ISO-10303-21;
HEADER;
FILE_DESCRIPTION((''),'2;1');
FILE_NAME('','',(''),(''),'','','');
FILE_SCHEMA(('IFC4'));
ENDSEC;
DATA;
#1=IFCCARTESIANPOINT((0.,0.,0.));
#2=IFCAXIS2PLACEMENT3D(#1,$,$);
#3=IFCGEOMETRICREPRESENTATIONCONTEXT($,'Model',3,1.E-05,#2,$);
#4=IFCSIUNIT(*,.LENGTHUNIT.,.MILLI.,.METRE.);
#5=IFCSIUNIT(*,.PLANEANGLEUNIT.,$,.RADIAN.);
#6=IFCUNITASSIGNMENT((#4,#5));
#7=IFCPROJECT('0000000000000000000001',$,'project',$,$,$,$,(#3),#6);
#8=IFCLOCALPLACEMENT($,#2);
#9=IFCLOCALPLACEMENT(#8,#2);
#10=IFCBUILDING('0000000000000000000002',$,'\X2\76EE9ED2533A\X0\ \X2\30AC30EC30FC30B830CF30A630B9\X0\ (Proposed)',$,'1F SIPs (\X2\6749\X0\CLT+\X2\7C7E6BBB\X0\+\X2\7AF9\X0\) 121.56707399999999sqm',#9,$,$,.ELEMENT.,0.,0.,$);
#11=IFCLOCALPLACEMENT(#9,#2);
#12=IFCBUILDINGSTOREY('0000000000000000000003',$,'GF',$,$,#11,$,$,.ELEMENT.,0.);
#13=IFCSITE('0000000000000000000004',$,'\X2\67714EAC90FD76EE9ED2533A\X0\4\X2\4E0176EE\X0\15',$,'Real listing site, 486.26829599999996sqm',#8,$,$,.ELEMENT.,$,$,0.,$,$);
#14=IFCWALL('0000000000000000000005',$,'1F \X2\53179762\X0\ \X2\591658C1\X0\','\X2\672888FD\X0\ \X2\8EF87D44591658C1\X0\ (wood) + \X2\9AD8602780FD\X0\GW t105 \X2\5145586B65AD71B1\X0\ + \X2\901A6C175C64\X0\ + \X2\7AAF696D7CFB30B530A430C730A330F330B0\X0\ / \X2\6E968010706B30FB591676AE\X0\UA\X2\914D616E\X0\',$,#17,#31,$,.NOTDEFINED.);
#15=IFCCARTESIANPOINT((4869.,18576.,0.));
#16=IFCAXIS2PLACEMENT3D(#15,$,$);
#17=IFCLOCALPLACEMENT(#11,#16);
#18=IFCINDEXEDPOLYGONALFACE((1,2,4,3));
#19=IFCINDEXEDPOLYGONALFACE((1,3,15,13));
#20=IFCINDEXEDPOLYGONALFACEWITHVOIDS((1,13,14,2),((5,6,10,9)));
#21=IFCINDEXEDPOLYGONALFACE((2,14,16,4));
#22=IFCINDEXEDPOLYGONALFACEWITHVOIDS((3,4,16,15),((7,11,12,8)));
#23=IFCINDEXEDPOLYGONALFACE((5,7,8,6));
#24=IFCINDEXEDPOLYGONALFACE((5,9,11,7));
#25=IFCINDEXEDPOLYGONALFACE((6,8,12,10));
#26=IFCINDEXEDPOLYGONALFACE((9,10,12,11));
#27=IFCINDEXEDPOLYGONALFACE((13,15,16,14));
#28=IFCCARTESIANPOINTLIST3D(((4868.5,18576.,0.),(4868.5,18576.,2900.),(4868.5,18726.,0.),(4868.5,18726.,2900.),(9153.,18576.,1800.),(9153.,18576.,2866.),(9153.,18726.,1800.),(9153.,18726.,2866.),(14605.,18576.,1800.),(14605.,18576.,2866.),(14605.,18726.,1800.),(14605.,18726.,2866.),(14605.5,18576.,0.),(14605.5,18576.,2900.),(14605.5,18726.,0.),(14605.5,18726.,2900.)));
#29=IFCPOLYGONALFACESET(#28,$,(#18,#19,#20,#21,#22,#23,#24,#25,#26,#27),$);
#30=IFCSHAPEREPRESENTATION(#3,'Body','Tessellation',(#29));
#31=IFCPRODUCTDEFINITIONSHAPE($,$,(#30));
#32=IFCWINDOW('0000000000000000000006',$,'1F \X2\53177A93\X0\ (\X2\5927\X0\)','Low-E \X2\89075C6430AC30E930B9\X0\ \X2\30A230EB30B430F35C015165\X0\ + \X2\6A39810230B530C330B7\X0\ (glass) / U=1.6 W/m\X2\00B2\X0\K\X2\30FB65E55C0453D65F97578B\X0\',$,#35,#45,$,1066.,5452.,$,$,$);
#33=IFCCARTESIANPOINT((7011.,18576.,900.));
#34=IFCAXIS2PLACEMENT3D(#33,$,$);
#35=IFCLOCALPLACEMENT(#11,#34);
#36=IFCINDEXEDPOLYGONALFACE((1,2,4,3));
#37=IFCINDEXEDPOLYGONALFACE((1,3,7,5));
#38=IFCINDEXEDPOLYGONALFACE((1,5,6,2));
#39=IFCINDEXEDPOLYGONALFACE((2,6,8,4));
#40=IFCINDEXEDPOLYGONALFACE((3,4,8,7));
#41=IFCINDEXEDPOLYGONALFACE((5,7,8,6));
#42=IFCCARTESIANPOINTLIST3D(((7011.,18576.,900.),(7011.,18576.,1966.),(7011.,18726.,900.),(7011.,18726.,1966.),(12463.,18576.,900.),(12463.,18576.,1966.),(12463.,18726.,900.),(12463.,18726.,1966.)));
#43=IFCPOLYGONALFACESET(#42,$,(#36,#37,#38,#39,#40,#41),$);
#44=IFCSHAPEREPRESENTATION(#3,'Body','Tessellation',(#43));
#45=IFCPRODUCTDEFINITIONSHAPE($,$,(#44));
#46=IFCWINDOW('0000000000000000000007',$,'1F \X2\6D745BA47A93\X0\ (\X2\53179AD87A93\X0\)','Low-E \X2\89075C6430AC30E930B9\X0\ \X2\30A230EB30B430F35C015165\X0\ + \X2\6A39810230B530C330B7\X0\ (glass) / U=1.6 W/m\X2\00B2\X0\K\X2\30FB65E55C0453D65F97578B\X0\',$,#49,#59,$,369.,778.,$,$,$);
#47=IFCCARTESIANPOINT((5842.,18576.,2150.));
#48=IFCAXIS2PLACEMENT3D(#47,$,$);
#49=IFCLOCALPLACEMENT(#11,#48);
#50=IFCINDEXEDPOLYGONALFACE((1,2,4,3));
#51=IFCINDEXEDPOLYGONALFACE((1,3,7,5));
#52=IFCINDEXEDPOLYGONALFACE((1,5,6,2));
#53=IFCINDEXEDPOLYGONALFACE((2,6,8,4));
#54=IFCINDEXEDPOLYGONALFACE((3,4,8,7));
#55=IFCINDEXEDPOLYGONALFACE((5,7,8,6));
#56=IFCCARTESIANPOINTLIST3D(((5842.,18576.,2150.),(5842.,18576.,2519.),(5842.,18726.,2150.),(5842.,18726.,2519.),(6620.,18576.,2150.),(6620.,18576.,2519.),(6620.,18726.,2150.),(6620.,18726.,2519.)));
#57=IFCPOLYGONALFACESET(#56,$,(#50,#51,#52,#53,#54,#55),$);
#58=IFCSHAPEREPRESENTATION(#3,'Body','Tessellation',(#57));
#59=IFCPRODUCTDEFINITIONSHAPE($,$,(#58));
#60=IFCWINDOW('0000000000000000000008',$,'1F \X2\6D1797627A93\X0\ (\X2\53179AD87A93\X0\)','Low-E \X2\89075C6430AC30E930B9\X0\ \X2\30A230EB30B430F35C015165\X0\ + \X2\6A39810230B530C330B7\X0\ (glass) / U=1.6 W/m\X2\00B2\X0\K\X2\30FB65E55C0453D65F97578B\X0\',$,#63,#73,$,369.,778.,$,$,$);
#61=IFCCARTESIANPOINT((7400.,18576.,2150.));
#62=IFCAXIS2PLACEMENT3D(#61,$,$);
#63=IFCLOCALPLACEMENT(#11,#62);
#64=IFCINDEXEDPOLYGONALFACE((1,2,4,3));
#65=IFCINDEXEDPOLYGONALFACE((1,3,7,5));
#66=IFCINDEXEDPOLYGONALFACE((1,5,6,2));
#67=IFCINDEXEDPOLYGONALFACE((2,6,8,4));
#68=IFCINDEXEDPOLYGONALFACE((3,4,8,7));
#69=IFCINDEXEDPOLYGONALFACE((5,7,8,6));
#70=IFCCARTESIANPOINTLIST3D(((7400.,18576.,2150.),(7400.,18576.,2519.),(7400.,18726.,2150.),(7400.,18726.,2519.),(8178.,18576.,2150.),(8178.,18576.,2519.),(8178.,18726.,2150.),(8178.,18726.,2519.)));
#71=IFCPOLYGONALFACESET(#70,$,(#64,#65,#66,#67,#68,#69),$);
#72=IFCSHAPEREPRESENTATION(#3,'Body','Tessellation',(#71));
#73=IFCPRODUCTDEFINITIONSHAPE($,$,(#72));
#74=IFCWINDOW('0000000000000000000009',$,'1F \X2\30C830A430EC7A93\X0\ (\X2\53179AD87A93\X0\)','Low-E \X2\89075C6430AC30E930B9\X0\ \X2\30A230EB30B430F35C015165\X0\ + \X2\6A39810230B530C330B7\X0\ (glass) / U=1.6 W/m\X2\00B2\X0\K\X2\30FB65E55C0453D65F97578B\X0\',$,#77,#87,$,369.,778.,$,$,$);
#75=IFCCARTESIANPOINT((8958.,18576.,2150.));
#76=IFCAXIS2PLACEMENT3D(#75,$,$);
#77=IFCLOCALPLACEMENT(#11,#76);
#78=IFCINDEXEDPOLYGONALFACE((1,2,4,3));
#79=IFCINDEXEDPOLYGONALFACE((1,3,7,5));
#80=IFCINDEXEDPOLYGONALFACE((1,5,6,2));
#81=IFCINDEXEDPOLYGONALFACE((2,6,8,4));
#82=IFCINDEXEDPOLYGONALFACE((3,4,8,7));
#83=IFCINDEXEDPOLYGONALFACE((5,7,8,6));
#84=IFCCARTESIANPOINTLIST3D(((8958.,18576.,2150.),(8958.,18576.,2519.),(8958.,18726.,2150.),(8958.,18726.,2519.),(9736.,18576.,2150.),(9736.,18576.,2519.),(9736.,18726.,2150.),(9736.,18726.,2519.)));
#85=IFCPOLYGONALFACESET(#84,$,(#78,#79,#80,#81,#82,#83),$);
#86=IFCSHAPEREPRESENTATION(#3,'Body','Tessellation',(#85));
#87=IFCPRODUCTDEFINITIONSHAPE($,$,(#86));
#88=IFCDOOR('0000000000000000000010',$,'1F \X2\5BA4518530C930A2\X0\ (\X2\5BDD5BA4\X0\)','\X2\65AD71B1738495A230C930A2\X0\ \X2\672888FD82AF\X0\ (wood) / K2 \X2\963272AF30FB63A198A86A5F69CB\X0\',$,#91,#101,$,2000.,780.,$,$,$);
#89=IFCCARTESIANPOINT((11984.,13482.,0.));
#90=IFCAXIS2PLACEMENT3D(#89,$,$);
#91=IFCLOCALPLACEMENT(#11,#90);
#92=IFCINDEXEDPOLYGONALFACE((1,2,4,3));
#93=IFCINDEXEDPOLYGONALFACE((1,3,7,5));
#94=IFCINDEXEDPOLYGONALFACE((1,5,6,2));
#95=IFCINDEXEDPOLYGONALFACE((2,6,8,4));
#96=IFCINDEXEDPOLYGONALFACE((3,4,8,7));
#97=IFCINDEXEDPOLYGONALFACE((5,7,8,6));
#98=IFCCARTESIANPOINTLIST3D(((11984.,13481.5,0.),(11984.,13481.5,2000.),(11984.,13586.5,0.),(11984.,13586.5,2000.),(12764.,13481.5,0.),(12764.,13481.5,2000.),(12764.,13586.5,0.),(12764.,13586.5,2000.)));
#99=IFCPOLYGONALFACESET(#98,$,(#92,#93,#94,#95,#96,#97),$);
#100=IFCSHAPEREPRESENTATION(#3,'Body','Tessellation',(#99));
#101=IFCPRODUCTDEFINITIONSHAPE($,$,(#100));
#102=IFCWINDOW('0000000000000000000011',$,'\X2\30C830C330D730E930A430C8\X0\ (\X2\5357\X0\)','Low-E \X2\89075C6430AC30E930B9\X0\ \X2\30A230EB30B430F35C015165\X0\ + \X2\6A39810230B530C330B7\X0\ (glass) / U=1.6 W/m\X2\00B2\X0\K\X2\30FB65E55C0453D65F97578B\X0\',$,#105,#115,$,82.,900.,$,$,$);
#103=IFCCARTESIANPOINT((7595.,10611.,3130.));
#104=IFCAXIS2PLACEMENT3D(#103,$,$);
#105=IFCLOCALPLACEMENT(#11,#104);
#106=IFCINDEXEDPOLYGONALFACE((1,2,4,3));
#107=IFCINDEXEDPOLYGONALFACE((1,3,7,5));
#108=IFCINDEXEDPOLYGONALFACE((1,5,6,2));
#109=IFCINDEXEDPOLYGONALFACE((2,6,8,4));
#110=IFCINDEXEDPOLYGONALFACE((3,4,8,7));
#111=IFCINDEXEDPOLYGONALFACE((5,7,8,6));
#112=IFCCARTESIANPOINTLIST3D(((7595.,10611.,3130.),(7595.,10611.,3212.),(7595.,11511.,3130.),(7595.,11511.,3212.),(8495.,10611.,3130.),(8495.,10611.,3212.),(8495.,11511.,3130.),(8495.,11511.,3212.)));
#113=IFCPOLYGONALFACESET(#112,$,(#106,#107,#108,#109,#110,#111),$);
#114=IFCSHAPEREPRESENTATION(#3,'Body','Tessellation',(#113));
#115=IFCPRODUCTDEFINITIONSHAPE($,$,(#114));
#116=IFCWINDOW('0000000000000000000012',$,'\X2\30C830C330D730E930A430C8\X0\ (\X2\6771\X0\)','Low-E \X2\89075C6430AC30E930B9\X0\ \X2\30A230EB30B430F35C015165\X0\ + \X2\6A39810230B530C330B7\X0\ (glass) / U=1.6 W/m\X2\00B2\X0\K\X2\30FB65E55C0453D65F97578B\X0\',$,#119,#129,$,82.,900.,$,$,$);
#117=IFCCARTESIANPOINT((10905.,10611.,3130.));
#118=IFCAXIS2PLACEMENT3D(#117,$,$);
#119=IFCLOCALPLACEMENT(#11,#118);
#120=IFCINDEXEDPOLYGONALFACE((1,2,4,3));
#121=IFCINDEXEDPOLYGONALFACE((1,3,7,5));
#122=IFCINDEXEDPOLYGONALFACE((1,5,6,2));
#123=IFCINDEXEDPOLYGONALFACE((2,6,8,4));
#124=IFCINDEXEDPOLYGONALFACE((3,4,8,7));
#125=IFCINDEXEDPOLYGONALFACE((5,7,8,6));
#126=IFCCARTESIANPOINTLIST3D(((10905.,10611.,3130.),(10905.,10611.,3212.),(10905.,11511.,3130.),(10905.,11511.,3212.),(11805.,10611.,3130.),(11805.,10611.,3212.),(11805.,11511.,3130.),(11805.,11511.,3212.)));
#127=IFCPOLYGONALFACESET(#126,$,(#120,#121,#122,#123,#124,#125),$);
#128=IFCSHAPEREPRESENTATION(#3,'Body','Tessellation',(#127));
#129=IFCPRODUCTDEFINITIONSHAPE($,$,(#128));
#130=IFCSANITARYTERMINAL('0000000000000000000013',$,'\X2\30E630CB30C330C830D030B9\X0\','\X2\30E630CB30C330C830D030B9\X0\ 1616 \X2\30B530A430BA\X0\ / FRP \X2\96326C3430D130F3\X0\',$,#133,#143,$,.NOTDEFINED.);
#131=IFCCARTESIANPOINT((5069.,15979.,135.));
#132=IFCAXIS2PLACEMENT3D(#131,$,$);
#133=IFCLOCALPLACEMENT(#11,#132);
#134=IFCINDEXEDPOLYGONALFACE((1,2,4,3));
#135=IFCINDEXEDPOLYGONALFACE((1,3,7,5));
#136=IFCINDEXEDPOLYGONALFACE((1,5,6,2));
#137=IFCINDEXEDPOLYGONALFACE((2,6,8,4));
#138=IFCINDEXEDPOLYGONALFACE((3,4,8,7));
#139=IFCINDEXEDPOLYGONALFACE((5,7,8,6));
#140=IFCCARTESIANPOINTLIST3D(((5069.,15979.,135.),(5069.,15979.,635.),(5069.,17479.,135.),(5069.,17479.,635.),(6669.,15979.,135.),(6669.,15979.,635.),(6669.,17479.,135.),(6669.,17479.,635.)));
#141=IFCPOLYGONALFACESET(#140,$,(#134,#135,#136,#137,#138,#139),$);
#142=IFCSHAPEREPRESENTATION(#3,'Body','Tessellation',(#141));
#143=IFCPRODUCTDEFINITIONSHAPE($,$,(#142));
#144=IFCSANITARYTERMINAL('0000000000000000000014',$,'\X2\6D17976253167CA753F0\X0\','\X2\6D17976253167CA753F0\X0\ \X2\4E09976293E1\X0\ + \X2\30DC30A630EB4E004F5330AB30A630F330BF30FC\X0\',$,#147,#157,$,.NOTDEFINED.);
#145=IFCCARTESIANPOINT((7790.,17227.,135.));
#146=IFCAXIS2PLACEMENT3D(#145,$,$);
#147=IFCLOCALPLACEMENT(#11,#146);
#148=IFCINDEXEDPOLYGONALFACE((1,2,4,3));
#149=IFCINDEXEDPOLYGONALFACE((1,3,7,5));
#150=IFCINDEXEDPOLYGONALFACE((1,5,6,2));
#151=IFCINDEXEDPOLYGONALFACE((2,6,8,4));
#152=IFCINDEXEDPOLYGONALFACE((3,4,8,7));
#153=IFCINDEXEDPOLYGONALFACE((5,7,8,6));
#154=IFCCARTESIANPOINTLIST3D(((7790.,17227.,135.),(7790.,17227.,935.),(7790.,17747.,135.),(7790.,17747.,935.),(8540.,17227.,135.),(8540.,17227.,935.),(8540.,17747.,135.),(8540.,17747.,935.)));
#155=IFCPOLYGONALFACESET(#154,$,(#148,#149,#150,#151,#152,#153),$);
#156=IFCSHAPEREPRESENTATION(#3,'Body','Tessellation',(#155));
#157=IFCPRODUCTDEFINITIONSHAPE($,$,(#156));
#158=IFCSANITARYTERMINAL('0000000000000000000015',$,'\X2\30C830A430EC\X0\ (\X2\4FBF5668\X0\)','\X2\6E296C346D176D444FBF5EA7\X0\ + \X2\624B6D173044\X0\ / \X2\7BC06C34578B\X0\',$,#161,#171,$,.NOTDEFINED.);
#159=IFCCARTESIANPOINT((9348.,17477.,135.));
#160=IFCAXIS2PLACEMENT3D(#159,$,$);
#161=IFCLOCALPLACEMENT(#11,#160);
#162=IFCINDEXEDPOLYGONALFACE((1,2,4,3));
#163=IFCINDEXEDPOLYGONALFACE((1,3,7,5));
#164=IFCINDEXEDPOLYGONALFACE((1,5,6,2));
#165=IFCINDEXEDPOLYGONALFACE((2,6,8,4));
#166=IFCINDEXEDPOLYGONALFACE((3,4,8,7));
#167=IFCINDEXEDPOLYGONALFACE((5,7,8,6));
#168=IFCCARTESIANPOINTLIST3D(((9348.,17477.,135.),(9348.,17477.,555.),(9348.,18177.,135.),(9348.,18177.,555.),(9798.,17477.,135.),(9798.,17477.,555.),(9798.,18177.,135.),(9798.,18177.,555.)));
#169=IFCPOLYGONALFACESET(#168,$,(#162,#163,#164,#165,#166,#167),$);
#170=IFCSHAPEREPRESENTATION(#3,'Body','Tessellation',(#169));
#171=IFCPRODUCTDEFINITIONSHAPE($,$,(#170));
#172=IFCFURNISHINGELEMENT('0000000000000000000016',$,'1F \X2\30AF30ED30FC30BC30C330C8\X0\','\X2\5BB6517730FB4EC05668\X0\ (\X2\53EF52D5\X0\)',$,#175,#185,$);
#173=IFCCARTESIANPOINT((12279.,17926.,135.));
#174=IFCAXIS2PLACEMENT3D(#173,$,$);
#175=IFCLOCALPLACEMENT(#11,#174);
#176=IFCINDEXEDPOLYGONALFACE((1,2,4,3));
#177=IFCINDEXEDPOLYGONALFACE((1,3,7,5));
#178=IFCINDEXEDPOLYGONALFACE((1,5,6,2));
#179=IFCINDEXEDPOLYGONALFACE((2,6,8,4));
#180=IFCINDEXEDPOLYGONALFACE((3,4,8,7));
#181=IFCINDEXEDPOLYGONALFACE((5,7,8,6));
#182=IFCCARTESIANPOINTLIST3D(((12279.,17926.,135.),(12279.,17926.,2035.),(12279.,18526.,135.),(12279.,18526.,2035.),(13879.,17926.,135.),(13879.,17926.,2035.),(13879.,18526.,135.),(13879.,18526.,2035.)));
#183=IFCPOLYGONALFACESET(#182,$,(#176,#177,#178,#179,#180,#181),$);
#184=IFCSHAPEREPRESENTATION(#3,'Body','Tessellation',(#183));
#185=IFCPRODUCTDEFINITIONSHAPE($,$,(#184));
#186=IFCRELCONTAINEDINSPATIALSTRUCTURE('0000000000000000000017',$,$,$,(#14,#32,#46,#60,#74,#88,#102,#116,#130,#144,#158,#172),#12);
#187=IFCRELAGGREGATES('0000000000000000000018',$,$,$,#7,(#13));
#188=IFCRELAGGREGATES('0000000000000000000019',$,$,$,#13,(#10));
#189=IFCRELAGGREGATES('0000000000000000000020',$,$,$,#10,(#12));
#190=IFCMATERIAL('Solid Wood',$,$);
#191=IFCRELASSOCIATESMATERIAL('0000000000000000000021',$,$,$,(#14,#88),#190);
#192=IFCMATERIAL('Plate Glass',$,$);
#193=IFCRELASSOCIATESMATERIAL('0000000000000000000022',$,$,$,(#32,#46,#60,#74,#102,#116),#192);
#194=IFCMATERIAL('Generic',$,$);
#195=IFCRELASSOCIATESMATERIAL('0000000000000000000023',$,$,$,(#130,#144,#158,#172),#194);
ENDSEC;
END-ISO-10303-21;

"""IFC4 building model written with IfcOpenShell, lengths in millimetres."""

from ifc_helpers import new_model, si_unit, frame, frame_2d, origin, place, context, project, spatial, rectangle, extrude, material, element, fill, save


model = new_model("IFC4")

# Units and contexts
model_context = context("Model", 3, precision=1e-05, world=origin())
ifc_project = project(units=[si_unit("LENGTHUNIT", "METRE", prefix="MILLI"), si_unit("PLANEANGLEUNIT", "RADIAN")], contexts=[model_context])

# Site, building, storey
site_placement = place(None, origin())
site = spatial("IfcSite", under=ifc_project, at=site_placement, Name="東京都目黒区4丁目15", ObjectType="Real listing site, 486.26829599999996sqm", CompositionType="ELEMENT", RefElevation=0.0)
building_placement = place(site_placement, origin())
building = spatial("IfcBuilding", under=site, at=building_placement, Name="目黒区 ガレージハウス (Proposed)", ObjectType="1F SIPs (杉CLT+籾殻+竹) 121.56707399999999sqm", CompositionType="ELEMENT", ElevationOfRefHeight=0.0, ElevationOfTerrain=0.0)
storey_placement = place(building_placement, origin())
storey = spatial("IfcBuildingStorey", under=building, at=storey_placement, Name="GF", CompositionType="ELEMENT", Elevation=0.0)

# Shared definitions
ifc_material_1 = material(Name="Solid Wood")

# Wall, openings, windows
wall_1_placement = place(storey_placement, frame((4869.0, 18576.0, 0.0)))
wall_1 = element("IfcWall", 1, at=wall_1_placement, inside=storey, material=ifc_material_1, Name="1F 北面 外壁", Description="木製 軸組外壁 (wood) + 高性能GW t105 充填断熱 + 通気層 + 窯業系サイディング / 準耐火・外皮UA配慮", PredefinedType="NOTDEFINED", context=model_context, shape_type="SweptSolid", body=[
    extrude(rectangle(XDim=9737.0, YDim=150.0, at=frame_2d((4868.0, 75.0))), frame((4869.0, 18576.0, 0.0)), (0.0, 0.0, 1.0), 2900.0),
])
opening_1_placement = place(storey_placement, frame((7011.0, 18576.0, 900.0)))
opening_1 = element("IfcOpeningElement", 2, at=opening_1_placement, cuts=wall_1, PredefinedType="NOTDEFINED", context=model_context, shape_type="SweptSolid", body=[
    extrude(rectangle(XDim=5452.0, YDim=150.0, at=frame_2d((2726.0, 75.0))), frame((7011.0, 18576.0, 900.0)), (0.0, 0.0, 1.0), 1066.0),
])
opening_2_placement = place(storey_placement, frame((5842.0, 18576.0, 2150.0)))
opening_2 = element("IfcOpeningElement", 3, at=opening_2_placement, cuts=wall_1, PredefinedType="NOTDEFINED", context=model_context, shape_type="SweptSolid", body=[
    extrude(rectangle(XDim=778.0, YDim=150.0, at=frame_2d((389.0, 75.0))), frame((5842.0, 18576.0, 2150.0)), (0.0, 0.0, 1.0), 369.0),
])
opening_3_placement = place(storey_placement, frame((7400.0, 18576.0, 2150.0)))
opening_3 = element("IfcOpeningElement", 4, at=opening_3_placement, cuts=wall_1, PredefinedType="NOTDEFINED", context=model_context, shape_type="SweptSolid", body=[
    extrude(rectangle(XDim=778.0, YDim=150.0, at=frame_2d((389.0, 75.0))), frame((7400.0, 18576.0, 2150.0)), (0.0, 0.0, 1.0), 369.0),
])
opening_4_placement = place(storey_placement, frame((8958.0, 18576.0, 2150.0)))
opening_4 = element("IfcOpeningElement", 5, at=opening_4_placement, cuts=wall_1, PredefinedType="NOTDEFINED", context=model_context, shape_type="SweptSolid", body=[
    extrude(rectangle(XDim=778.0, YDim=150.0, at=frame_2d((389.0, 75.0))), frame((8958.0, 18576.0, 2150.0)), (0.0, 0.0, 1.0), 369.0),
])
ifc_material_2 = material(Name="Plate Glass")
window_1_placement = place(storey_placement, frame((7011.0, 18576.0, 900.0)))
window_1 = element("IfcWindow", 6, at=window_1_placement, inside=storey, material=ifc_material_2, Name="1F 北窓 (大)", Description="Low-E 複層ガラス アルゴン封入 + 樹脂サッシ (glass) / U=1.6 W/m²K・日射取得型", OverallHeight=1066.0, OverallWidth=5452.0, context=model_context, shape_type="SweptSolid", body=[
    extrude(rectangle(XDim=5452.0, YDim=150.0, at=frame_2d((2726.0, 75.0))), frame((7011.0, 18576.0, 900.0)), (0.0, 0.0, 1.0), 1066.0),
])
fill(opening_1, window_1)
window_2_placement = place(storey_placement, frame((5842.0, 18576.0, 2150.0)))
window_2 = element("IfcWindow", 7, at=window_2_placement, inside=storey, material=ifc_material_2, Name="1F 浴室窓 (北高窓)", Description="Low-E 複層ガラス アルゴン封入 + 樹脂サッシ (glass) / U=1.6 W/m²K・日射取得型", OverallHeight=369.0, OverallWidth=778.0, context=model_context, shape_type="SweptSolid", body=[
    extrude(rectangle(XDim=778.0, YDim=150.0, at=frame_2d((389.0, 75.0))), frame((5842.0, 18576.0, 2150.0)), (0.0, 0.0, 1.0), 369.0),
])
fill(opening_2, window_2)
window_3_placement = place(storey_placement, frame((7400.0, 18576.0, 2150.0)))
window_3 = element("IfcWindow", 8, at=window_3_placement, inside=storey, material=ifc_material_2, Name="1F 洗面窓 (北高窓)", Description="Low-E 複層ガラス アルゴン封入 + 樹脂サッシ (glass) / U=1.6 W/m²K・日射取得型", OverallHeight=369.0, OverallWidth=778.0, context=model_context, shape_type="SweptSolid", body=[
    extrude(rectangle(XDim=778.0, YDim=150.0, at=frame_2d((389.0, 75.0))), frame((7400.0, 18576.0, 2150.0)), (0.0, 0.0, 1.0), 369.0),
])
fill(opening_3, window_3)
window_4_placement = place(storey_placement, frame((8958.0, 18576.0, 2150.0)))
window_4 = element("IfcWindow", 9, at=window_4_placement, inside=storey, material=ifc_material_2, Name="1F トイレ窓 (北高窓)", Description="Low-E 複層ガラス アルゴン封入 + 樹脂サッシ (glass) / U=1.6 W/m²K・日射取得型", OverallHeight=369.0, OverallWidth=778.0, context=model_context, shape_type="SweptSolid", body=[
    extrude(rectangle(XDim=778.0, YDim=150.0, at=frame_2d((389.0, 75.0))), frame((8958.0, 18576.0, 2150.0)), (0.0, 0.0, 1.0), 369.0),
])
fill(opening_4, window_4)

# Door
door_1_placement = place(storey_placement, frame((11984.0, 13482.0, 0.0)))
element("IfcDoor", 10, at=door_1_placement, inside=storey, material=ifc_material_1, Name="1F 室内ドア (寝室)", Description="断熱玄関ドア 木製芯 (wood) / K2 防犯・採風機構", OverallHeight=2000.0, OverallWidth=780.0, context=model_context, shape_type="SweptSolid", body=[
    extrude(rectangle(XDim=780.0, YDim=105.0, at=frame_2d((390.0, 52.0))), frame((11984.0, 13482.0, 0.0)), (0.0, 0.0, 1.0), 2000.0),
])

# Windows
window_5_placement = place(storey_placement, frame((7595.0, 10611.0, 3130.0)))
element("IfcWindow", 11, at=window_5_placement, inside=storey, material=ifc_material_2, Name="トップライト (南)", Description="Low-E 複層ガラス アルゴン封入 + 樹脂サッシ (glass) / U=1.6 W/m²K・日射取得型", OverallHeight=82.0, OverallWidth=900.0, context=model_context, shape_type="SweptSolid", body=[
    extrude(rectangle(XDim=900.0, YDim=900.0, at=frame_2d((450.0, 450.0))), frame((7595.0, 10611.0, 3130.0)), (0.0, 0.0, 1.0), 82.0),
])
window_6_placement = place(storey_placement, frame((10905.0, 10611.0, 3130.0)))
element("IfcWindow", 12, at=window_6_placement, inside=storey, material=ifc_material_2, Name="トップライト (東)", Description="Low-E 複層ガラス アルゴン封入 + 樹脂サッシ (glass) / U=1.6 W/m²K・日射取得型", OverallHeight=82.0, OverallWidth=900.0, context=model_context, shape_type="SweptSolid", body=[
    extrude(rectangle(XDim=900.0, YDim=900.0, at=frame_2d((450.0, 450.0))), frame((10905.0, 10611.0, 3130.0)), (0.0, 0.0, 1.0), 82.0),
])

# Sanitary terminals
ifc_material_3 = material(Name="Generic")
sanitary_terminal_1_placement = place(storey_placement, frame((5069.0, 15979.0, 135.0)))
element("IfcSanitaryTerminal", 13, at=sanitary_terminal_1_placement, inside=storey, material=ifc_material_3, Name="ユニットバス", Description="ユニットバス 1616 サイズ / FRP 防水パン", PredefinedType="NOTDEFINED", context=model_context, shape_type="SweptSolid", body=[
    extrude(rectangle(XDim=1600.0, YDim=1500.0, at=frame_2d((800.0, 750.0))), frame((5069.0, 15979.0, 135.0)), (0.0, 0.0, 1.0), 500.0),
])
sanitary_terminal_2_placement = place(storey_placement, frame((7790.0, 17227.0, 135.0)))
element("IfcSanitaryTerminal", 14, at=sanitary_terminal_2_placement, inside=storey, material=ifc_material_3, Name="洗面化粧台", Description="洗面化粧台 三面鏡 + ボウル一体カウンター", PredefinedType="NOTDEFINED", context=model_context, shape_type="SweptSolid", body=[
    extrude(rectangle(XDim=750.0, YDim=520.0, at=frame_2d((375.0, 260.0))), frame((7790.0, 17227.0, 135.0)), (0.0, 0.0, 1.0), 800.0),
])
sanitary_terminal_3_placement = place(storey_placement, frame((9348.0, 17477.0, 135.0)))
element("IfcSanitaryTerminal", 15, at=sanitary_terminal_3_placement, inside=storey, material=ifc_material_3, Name="トイレ (便器)", Description="温水洗浄便座 + 手洗い / 節水型", PredefinedType="NOTDEFINED", context=model_context, shape_type="SweptSolid", body=[
    extrude(rectangle(XDim=450.0, YDim=700.0, at=frame_2d((225.0, 350.0))), frame((9348.0, 17477.0, 135.0)), (0.0, 0.0, 1.0), 420.0),
])

# Furnishing element
furnishing_1_placement = place(storey_placement, frame((12279.0, 17926.0, 135.0)))
element("IfcFurnishingElement", 16, at=furnishing_1_placement, inside=storey, material=ifc_material_3, Name="1F クローゼット", Description="家具・什器 (可動)", context=model_context, shape_type="SweptSolid", body=[
    extrude(rectangle(XDim=1600.0, YDim=600.0, at=frame_2d((800.0, 300.0))), frame((12279.0, 17926.0, 135.0)), (0.0, 0.0, 1.0), 1900.0),
])

save(model, "model.ifc")
